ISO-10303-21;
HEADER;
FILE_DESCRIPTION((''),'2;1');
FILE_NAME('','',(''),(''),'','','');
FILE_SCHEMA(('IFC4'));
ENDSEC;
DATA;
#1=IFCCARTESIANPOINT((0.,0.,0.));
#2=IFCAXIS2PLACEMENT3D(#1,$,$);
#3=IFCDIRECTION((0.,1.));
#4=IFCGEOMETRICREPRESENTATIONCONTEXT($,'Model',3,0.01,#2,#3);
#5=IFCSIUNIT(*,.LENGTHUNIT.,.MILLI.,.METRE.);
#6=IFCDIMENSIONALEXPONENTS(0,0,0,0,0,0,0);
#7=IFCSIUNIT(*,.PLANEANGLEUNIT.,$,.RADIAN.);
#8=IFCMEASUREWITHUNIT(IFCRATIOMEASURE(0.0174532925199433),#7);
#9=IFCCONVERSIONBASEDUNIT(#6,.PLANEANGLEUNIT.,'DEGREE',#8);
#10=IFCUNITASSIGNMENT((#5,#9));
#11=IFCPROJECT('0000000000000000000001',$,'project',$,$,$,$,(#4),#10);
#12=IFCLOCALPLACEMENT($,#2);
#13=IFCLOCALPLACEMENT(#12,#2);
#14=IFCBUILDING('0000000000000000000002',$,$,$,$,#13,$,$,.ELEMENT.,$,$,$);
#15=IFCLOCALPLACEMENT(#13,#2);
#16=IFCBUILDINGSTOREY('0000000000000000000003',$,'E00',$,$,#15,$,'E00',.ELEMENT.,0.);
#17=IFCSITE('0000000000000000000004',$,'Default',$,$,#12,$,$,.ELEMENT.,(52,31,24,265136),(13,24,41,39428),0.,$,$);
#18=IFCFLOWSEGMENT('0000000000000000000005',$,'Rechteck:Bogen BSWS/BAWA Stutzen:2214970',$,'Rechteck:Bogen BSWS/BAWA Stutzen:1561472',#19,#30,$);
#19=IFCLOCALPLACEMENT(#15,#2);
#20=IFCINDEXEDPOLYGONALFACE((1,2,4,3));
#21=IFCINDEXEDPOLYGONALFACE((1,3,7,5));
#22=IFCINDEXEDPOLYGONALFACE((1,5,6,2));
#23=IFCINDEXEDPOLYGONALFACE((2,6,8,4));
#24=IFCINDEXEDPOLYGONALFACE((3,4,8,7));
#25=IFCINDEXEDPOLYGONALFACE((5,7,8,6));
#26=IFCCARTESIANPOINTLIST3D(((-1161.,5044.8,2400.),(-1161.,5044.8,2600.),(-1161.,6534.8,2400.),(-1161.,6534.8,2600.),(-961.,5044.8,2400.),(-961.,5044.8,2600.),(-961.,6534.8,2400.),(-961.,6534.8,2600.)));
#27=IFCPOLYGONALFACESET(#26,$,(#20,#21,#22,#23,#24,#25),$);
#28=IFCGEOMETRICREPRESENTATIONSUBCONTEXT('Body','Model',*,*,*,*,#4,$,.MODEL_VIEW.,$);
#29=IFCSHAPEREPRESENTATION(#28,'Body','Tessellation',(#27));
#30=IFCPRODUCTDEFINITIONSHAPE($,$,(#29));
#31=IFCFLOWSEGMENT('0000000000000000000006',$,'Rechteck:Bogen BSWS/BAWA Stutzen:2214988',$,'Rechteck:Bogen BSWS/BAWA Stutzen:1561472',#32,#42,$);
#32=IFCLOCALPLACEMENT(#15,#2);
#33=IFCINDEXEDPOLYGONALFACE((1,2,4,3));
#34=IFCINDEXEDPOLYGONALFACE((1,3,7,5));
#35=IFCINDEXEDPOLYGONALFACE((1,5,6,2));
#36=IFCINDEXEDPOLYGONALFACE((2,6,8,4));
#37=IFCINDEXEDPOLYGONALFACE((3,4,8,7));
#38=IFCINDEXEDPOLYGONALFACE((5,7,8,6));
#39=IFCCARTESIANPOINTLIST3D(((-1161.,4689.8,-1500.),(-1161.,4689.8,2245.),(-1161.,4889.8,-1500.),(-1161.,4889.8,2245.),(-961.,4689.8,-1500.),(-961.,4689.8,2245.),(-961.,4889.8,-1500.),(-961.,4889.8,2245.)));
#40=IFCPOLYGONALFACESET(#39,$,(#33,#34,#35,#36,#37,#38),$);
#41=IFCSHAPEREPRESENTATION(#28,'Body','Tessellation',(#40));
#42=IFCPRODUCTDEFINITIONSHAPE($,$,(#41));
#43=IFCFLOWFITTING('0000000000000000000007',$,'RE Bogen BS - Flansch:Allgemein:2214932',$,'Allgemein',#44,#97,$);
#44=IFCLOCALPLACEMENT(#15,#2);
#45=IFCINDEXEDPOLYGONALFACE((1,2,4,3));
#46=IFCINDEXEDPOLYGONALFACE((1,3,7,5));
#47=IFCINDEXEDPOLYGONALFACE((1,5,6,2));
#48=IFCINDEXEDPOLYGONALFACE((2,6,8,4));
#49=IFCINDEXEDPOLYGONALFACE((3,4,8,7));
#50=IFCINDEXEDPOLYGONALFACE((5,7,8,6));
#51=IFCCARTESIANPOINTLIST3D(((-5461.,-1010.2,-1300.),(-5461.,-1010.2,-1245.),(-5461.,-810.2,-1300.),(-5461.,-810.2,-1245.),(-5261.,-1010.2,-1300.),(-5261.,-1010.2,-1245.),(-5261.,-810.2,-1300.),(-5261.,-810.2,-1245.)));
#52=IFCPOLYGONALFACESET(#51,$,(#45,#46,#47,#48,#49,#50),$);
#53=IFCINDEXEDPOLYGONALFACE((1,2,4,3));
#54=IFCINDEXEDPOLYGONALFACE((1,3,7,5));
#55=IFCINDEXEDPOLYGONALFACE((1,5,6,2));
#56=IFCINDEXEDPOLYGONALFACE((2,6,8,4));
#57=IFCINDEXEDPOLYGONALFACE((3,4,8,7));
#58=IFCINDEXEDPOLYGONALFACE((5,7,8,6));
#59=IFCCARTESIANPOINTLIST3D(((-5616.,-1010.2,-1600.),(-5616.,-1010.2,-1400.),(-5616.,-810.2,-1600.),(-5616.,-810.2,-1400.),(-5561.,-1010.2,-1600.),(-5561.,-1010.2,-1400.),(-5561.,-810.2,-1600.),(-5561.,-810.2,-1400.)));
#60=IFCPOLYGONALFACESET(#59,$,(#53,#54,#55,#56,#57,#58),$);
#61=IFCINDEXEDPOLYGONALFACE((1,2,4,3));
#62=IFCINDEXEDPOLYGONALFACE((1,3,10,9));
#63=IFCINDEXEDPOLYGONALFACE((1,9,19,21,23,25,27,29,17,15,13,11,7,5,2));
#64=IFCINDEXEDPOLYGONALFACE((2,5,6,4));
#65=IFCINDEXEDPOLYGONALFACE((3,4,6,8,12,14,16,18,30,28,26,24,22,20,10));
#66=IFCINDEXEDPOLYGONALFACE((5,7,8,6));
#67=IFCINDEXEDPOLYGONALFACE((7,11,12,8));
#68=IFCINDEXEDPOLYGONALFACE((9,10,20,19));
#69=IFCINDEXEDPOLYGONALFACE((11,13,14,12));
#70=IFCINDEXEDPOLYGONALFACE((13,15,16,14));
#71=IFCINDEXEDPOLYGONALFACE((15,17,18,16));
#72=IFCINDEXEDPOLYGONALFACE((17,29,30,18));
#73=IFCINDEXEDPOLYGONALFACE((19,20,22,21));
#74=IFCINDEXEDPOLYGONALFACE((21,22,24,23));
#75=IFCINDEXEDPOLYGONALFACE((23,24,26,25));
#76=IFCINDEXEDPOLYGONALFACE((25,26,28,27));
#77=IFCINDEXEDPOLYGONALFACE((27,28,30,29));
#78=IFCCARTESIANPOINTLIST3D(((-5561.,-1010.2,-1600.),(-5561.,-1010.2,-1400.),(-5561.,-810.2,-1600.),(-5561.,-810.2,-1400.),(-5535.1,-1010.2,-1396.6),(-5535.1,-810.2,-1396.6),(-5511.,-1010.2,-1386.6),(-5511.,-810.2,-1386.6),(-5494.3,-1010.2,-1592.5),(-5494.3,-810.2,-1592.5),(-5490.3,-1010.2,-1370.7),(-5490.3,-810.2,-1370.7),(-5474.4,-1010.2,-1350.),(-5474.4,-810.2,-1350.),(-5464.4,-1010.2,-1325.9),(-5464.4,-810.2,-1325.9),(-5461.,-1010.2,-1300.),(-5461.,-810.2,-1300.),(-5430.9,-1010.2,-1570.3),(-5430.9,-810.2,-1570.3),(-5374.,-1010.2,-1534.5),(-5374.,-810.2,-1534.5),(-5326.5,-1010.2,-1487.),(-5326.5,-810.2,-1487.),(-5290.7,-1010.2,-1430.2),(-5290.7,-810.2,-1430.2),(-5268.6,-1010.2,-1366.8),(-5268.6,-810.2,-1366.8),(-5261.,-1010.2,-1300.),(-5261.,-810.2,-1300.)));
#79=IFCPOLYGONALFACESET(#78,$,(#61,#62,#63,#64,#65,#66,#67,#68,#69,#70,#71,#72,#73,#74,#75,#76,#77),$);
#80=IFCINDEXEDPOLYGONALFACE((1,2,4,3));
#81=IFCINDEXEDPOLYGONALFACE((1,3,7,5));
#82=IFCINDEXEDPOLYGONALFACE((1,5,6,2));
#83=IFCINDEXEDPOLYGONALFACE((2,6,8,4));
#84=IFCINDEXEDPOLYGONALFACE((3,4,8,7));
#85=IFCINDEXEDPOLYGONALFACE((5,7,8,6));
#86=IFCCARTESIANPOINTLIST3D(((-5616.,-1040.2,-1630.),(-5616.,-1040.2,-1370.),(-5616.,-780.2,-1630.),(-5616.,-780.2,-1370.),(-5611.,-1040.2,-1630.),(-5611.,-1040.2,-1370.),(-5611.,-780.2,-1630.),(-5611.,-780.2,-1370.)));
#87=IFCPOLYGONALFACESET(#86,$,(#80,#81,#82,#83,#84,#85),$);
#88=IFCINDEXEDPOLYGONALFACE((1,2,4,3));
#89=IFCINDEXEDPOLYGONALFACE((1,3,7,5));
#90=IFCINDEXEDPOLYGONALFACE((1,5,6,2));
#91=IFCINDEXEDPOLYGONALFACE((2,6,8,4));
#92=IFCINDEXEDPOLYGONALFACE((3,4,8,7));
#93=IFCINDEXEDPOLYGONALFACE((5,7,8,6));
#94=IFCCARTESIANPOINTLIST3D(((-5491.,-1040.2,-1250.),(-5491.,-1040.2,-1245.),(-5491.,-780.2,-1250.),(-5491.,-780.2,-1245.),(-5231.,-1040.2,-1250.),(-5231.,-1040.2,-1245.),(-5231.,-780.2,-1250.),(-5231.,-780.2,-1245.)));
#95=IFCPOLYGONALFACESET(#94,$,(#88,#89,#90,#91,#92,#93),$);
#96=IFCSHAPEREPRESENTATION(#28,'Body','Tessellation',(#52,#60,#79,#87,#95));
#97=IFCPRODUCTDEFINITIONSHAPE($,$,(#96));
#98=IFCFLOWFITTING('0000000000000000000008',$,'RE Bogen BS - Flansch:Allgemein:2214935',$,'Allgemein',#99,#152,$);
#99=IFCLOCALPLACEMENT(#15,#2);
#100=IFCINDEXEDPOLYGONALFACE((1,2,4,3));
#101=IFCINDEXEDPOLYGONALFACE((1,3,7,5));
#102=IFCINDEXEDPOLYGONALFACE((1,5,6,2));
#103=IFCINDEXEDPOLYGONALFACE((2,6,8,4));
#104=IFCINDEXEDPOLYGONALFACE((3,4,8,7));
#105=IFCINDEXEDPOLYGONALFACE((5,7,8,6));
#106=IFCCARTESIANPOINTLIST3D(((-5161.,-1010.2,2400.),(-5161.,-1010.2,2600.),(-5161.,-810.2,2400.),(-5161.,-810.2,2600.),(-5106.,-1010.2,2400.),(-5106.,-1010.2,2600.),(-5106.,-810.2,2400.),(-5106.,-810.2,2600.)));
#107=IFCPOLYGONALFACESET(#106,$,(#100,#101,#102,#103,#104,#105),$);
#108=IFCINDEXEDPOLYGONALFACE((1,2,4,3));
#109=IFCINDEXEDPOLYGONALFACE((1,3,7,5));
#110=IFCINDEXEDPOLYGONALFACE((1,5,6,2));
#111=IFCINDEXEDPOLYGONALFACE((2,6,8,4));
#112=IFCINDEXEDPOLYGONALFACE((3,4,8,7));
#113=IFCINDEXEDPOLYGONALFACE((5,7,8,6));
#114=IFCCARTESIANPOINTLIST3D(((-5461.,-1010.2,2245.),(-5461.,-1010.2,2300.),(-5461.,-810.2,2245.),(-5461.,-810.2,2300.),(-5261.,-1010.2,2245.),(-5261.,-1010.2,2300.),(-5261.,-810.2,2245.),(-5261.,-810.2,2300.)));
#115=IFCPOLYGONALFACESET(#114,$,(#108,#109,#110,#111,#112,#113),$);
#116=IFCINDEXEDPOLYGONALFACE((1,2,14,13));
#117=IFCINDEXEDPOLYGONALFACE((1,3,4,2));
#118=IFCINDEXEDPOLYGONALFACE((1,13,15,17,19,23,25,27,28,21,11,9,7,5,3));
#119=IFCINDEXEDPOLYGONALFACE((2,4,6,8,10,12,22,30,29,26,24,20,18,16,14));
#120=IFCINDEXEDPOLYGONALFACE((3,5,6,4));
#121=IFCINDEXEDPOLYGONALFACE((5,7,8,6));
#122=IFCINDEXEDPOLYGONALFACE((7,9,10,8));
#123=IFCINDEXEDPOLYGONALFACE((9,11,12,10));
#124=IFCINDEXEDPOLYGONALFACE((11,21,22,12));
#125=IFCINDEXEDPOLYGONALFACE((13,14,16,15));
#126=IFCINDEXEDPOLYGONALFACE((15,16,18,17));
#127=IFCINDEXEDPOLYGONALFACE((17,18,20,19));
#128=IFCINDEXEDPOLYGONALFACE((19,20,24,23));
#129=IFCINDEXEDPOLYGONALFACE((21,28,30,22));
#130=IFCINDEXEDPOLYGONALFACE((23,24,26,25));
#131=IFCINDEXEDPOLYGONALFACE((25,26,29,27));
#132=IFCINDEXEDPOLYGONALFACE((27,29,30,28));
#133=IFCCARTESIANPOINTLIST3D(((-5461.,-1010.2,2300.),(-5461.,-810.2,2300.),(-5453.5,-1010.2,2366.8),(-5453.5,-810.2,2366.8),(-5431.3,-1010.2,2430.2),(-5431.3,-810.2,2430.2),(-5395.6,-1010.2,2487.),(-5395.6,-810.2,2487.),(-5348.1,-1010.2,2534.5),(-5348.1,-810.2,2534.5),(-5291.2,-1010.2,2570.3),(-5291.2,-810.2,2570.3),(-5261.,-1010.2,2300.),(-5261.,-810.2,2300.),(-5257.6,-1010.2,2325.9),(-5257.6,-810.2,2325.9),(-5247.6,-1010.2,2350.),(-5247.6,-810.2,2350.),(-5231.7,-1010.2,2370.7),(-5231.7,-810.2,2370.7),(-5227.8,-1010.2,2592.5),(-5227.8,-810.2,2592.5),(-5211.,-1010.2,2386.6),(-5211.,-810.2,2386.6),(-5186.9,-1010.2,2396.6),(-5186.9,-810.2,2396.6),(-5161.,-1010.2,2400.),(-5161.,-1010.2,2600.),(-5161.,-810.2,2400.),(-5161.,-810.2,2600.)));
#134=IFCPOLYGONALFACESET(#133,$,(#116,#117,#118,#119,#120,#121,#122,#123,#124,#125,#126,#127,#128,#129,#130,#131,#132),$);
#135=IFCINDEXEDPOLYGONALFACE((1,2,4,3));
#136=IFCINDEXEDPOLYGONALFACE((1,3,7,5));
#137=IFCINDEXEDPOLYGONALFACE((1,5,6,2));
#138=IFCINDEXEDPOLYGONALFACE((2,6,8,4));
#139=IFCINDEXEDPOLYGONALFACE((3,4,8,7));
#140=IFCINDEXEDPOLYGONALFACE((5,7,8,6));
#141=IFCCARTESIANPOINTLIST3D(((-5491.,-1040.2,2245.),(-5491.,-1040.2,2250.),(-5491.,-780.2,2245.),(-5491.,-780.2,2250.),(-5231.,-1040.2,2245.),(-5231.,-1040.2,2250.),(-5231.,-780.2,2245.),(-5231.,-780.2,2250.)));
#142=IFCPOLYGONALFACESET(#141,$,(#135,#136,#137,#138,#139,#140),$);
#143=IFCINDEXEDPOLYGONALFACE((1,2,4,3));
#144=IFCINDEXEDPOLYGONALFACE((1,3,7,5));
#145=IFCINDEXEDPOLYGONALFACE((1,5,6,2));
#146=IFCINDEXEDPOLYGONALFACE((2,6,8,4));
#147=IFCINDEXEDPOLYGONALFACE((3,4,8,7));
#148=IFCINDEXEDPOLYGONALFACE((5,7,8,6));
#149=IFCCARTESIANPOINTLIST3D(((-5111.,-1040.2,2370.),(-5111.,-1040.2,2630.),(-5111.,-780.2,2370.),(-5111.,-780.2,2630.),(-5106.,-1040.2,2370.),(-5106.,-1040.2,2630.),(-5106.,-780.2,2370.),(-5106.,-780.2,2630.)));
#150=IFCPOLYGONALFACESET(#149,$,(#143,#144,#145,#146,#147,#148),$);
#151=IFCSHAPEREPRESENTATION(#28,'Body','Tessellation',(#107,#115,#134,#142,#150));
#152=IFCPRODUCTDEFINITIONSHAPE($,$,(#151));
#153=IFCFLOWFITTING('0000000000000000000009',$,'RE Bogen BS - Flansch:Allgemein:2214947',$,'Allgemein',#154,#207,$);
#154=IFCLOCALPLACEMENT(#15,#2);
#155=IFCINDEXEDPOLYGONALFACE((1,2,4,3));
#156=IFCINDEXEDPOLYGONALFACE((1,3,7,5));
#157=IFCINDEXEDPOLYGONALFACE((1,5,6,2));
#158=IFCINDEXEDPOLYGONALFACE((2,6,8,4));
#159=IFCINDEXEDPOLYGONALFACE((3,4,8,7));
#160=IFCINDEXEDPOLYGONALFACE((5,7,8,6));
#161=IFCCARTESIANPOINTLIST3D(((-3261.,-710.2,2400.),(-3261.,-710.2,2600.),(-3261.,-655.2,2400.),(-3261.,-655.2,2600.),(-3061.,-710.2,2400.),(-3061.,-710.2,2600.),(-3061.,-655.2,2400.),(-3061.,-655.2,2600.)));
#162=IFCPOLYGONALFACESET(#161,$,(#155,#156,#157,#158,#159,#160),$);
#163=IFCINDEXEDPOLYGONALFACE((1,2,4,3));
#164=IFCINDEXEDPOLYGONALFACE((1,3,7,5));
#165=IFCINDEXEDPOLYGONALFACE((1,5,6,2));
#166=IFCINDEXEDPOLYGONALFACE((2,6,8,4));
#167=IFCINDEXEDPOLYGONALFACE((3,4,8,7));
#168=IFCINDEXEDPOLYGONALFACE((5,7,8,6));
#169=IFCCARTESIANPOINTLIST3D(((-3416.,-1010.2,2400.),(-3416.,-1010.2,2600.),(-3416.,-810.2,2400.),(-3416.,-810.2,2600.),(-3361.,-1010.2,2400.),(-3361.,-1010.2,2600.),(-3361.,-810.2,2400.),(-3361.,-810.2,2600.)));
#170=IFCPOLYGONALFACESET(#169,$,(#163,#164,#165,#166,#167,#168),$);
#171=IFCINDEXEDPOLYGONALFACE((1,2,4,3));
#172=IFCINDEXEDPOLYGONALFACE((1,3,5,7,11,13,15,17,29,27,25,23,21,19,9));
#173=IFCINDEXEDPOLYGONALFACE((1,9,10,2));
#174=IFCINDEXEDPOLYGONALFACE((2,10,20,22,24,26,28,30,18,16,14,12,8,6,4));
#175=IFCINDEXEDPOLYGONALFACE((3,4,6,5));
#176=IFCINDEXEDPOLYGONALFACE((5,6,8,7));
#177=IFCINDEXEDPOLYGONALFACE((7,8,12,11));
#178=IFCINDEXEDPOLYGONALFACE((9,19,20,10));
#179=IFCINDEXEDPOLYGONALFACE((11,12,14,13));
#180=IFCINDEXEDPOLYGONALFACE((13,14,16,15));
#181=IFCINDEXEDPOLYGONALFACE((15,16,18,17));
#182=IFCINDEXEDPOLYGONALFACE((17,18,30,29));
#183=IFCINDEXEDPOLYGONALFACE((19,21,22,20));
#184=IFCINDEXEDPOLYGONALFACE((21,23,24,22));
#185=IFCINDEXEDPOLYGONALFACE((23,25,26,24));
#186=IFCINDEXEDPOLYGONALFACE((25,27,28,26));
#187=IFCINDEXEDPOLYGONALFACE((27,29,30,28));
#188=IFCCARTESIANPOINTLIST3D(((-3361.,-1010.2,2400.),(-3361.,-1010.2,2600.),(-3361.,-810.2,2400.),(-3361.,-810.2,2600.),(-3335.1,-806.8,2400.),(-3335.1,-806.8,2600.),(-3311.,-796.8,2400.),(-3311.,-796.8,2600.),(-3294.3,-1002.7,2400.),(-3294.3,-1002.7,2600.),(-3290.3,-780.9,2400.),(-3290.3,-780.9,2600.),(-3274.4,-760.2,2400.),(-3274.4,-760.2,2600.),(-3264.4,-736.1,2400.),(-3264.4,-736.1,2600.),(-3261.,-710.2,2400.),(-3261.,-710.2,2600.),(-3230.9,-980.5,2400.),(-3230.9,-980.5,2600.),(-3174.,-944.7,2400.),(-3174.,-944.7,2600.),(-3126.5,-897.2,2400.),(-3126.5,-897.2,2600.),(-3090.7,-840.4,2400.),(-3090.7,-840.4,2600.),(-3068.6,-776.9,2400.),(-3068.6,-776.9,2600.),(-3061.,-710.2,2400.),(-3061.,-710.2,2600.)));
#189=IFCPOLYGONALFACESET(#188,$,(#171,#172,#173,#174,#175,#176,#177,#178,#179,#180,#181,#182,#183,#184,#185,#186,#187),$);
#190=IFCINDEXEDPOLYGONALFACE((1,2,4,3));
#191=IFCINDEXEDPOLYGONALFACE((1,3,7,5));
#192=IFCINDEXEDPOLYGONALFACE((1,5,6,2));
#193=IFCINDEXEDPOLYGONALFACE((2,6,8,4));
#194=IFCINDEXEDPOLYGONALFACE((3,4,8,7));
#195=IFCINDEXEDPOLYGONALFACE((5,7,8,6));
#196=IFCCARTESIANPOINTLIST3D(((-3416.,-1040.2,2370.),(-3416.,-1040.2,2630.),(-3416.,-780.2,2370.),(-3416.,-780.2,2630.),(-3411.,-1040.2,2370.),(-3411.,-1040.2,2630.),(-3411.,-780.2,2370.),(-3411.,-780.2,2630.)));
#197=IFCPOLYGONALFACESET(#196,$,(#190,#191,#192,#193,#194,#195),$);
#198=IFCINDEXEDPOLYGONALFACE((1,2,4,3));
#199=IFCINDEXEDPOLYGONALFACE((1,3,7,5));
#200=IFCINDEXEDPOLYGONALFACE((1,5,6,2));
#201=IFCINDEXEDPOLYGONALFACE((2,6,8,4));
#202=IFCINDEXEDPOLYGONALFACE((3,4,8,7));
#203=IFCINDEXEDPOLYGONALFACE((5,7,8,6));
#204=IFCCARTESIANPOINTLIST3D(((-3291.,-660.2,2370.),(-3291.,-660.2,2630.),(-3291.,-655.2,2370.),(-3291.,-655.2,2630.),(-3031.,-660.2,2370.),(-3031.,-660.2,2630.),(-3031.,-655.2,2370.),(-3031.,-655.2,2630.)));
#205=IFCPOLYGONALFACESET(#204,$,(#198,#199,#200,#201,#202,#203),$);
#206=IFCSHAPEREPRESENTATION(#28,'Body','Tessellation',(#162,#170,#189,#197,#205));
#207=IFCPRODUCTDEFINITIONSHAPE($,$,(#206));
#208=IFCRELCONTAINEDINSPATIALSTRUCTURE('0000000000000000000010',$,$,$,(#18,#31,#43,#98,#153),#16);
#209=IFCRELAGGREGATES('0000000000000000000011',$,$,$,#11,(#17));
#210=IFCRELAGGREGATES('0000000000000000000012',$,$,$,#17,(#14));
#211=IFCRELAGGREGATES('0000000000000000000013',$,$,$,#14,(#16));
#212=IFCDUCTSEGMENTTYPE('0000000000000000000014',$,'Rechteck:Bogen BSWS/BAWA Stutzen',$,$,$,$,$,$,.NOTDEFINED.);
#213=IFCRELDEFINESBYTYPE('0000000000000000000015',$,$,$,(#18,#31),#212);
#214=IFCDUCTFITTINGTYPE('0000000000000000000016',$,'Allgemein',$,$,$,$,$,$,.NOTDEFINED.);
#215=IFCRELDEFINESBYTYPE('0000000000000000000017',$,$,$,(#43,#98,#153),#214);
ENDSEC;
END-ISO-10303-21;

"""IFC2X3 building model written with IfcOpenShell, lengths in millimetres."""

from ifc_helpers import new_model, entity, si_unit, converted_unit, direction, frame, frame_2d, origin, origin_2d_with_axis, place, context, subcontext, project, spatial, polyline, circle_curve, parameter, trimmed, segment, composite_curve, rectangle, outline, extrude, source, transform, mapped, type_object, type_shapes, element, save


model = new_model("IFC2X3")

# Units and contexts
model_context = context("Model", 3, precision=0.01, world=origin(), true_north=direction((0.0, 1.0)))
body_context = subcontext(model_context, "Body", "Model", "MODEL_VIEW")
ifc_project = project(units=[si_unit("LENGTHUNIT", "METRE", prefix="MILLI"), converted_unit("PLANEANGLEUNIT", "DEGREE", entity("IfcRatioMeasure", 0.0174532925199433), si_unit("PLANEANGLEUNIT", "RADIAN"), dimensions=[0, 0, 0, 0, 0, 0, 0])], contexts=[model_context])

# Site, building, storey
site_placement = place(None, origin())
site = spatial("IfcSite", under=ifc_project, at=site_placement, Name="Default", CompositionType="ELEMENT", RefLatitude=(52, 31, 24, 265136), RefLongitude=(13, 24, 41, 39428), RefElevation=0.0)
building_placement = place(site_placement, origin())
building = spatial("IfcBuilding", under=site, at=building_placement, CompositionType="ELEMENT")
storey_placement = place(building_placement, origin())
storey = spatial("IfcBuildingStorey", under=building, at=storey_placement, Name="E00", LongName="E00", CompositionType="ELEMENT", Elevation=0.0)

# Flow segments
duct_segment_type = type_object("IfcDuctSegmentType", Name="Rechteck:Bogen BSWS/BAWA Stutzen", PredefinedType="NOTDEFINED")
flow_segment_1_placement = place(storey_placement, origin())
element("IfcFlowSegment", 1, at=flow_segment_1_placement, inside=storey, type_object=duct_segment_type, Name="Rechteck:Bogen BSWS/BAWA Stutzen:2214970", ObjectType="Rechteck:Bogen BSWS/BAWA Stutzen:1561472", context=body_context, shape_type="SweptSolid", body=[
    extrude(rectangle(XDim=1490.0, YDim=200.0, at=frame_2d((0.0, 0.0), x_axis=(1.0, 0.0))), frame((-1061.0, 5789.8, 2400.0), z_axis=(0.0, 0.0, 1.0), x_axis=(0.0, -1.0, 0.0)), (0.0, 0.0, 1.0), 200.0),
])
flow_segment_2_placement = place(storey_placement, origin())
element("IfcFlowSegment", 2, at=flow_segment_2_placement, inside=storey, type_object=duct_segment_type, Name="Rechteck:Bogen BSWS/BAWA Stutzen:2214988", ObjectType="Rechteck:Bogen BSWS/BAWA Stutzen:1561472", context=body_context, shape_type="SweptSolid", body=[
    extrude(rectangle(XDim=200.0, YDim=200.0, at=origin_2d_with_axis()), frame((-1061.0, 4789.8, -1500.0), z_axis=(0.0, 0.0, 1.0), x_axis=(0.0, -1.0, 0.0)), (0.0, 0.0, 1.0), 3745.0),
])

# Flow fittings
duct_fitting_type = type_object("IfcDuctFittingType", Name="Allgemein", PredefinedType="NOTDEFINED")
shared_shape = source(origin(), body_context, "Body", "SweptSolid", [
    extrude(rectangle(XDim=55.0, YDim=200.0, at=frame_2d((0.0, 0.0), x_axis=(1.0, 0.0))), frame((0.0, 227.5, -100.0), z_axis=(0.0, 0.0, 1.0), x_axis=(0.0, 1.0, 0.0)), (0.0, 0.0, 1.0), 200.0),
    extrude(rectangle(XDim=200.0, YDim=55.0, at=frame_2d((0.0, 0.0), x_axis=(1.0, 0.0))), frame((-227.5, 0.0, -100.0), z_axis=(0.0, 0.0, 1.0), x_axis=(0.0, -1.0, 0.0)), (0.0, 0.0, 1.0), 200.0),
    extrude(outline(composite_curve([segment(polyline([(-200.0, -100.0), (0.0, -100.0)]), True, "CONTINUOUS"), segment(trimmed(circle_curve(frame_2d((100.0, -100.0), x_axis=(0.0, 1.0)), 100.0), [parameter(0.0)], [parameter(90.0)], True, "PARAMETER"), False, "CONTINUOUS"), segment(polyline([(100.0, 0.0), (100.0, 200.0)]), True, "CONTINUOUS"), segment(trimmed(circle_curve(frame_2d((100.0, -100.0), x_axis=(0.0, 1.0)), 300.0), [parameter(0.0)], [parameter(90.0)], True, "PARAMETER"), True, "CONTINUOUS")], self_intersect=False)), frame((-100.0, 100.0, -100.0), z_axis=(0.0, 0.0, 1.0), x_axis=(-1.0, 0.0, 0.0)), (0.0, 0.0, 1.0), 200.0),
    extrude(rectangle(XDim=5.0, YDim=260.0, at=frame_2d((0.0, 0.0), x_axis=(1.0, 0.0))), frame((-252.5, 0.0, -130.0)), (0.0, 0.0, 1.0), 260.0),
    extrude(rectangle(XDim=5.0, YDim=260.0, at=frame_2d((0.0, 0.0), x_axis=(1.0, 0.0))), frame((0.0, 252.5, -130.0), z_axis=(0.0, 0.0, 1.0), x_axis=(0.0, 1.0, 0.0)), (0.0, 0.0, 1.0), 260.0),
])
type_shapes(duct_fitting_type, [shared_shape])
for number, where, z_axis, x_axis, name in (
    (3, (-5361.0, -910.2, -1500.0), (0.0, -1.0, 0.0), (1.0, 0.0, 0.0), "RE Bogen BS - Flansch:Allgemein:2214932"),
    (4, (-5361.0, -910.2, 2500.0), (0.0, 1.0, 0.0), (0.0, 0.0, 1.0), "RE Bogen BS - Flansch:Allgemein:2214935"),
):
    element("IfcFlowFitting", number, at=place(storey_placement, frame(where, z_axis=z_axis, x_axis=x_axis)), inside=storey, type_object=duct_fitting_type, Name=name, ObjectType="Allgemein", context=body_context, shape_type="MappedRepresentation", body=[
        mapped(shared_shape, transform((0.0, 0.0, 0.0), scale=1.0)),
    ])
flow_fitting_placement = place(storey_placement, frame((-3161.0, -910.2, 2500.0)))
element("IfcFlowFitting", 5, at=flow_fitting_placement, inside=storey, type_object=duct_fitting_type, Name="RE Bogen BS - Flansch:Allgemein:2214947", ObjectType="Allgemein", context=body_context, shape_type="MappedRepresentation", body=[
    mapped(shared_shape, transform((0.0, 0.0, 0.0), scale=1.0)),
])

save(model, "model.ifc")
